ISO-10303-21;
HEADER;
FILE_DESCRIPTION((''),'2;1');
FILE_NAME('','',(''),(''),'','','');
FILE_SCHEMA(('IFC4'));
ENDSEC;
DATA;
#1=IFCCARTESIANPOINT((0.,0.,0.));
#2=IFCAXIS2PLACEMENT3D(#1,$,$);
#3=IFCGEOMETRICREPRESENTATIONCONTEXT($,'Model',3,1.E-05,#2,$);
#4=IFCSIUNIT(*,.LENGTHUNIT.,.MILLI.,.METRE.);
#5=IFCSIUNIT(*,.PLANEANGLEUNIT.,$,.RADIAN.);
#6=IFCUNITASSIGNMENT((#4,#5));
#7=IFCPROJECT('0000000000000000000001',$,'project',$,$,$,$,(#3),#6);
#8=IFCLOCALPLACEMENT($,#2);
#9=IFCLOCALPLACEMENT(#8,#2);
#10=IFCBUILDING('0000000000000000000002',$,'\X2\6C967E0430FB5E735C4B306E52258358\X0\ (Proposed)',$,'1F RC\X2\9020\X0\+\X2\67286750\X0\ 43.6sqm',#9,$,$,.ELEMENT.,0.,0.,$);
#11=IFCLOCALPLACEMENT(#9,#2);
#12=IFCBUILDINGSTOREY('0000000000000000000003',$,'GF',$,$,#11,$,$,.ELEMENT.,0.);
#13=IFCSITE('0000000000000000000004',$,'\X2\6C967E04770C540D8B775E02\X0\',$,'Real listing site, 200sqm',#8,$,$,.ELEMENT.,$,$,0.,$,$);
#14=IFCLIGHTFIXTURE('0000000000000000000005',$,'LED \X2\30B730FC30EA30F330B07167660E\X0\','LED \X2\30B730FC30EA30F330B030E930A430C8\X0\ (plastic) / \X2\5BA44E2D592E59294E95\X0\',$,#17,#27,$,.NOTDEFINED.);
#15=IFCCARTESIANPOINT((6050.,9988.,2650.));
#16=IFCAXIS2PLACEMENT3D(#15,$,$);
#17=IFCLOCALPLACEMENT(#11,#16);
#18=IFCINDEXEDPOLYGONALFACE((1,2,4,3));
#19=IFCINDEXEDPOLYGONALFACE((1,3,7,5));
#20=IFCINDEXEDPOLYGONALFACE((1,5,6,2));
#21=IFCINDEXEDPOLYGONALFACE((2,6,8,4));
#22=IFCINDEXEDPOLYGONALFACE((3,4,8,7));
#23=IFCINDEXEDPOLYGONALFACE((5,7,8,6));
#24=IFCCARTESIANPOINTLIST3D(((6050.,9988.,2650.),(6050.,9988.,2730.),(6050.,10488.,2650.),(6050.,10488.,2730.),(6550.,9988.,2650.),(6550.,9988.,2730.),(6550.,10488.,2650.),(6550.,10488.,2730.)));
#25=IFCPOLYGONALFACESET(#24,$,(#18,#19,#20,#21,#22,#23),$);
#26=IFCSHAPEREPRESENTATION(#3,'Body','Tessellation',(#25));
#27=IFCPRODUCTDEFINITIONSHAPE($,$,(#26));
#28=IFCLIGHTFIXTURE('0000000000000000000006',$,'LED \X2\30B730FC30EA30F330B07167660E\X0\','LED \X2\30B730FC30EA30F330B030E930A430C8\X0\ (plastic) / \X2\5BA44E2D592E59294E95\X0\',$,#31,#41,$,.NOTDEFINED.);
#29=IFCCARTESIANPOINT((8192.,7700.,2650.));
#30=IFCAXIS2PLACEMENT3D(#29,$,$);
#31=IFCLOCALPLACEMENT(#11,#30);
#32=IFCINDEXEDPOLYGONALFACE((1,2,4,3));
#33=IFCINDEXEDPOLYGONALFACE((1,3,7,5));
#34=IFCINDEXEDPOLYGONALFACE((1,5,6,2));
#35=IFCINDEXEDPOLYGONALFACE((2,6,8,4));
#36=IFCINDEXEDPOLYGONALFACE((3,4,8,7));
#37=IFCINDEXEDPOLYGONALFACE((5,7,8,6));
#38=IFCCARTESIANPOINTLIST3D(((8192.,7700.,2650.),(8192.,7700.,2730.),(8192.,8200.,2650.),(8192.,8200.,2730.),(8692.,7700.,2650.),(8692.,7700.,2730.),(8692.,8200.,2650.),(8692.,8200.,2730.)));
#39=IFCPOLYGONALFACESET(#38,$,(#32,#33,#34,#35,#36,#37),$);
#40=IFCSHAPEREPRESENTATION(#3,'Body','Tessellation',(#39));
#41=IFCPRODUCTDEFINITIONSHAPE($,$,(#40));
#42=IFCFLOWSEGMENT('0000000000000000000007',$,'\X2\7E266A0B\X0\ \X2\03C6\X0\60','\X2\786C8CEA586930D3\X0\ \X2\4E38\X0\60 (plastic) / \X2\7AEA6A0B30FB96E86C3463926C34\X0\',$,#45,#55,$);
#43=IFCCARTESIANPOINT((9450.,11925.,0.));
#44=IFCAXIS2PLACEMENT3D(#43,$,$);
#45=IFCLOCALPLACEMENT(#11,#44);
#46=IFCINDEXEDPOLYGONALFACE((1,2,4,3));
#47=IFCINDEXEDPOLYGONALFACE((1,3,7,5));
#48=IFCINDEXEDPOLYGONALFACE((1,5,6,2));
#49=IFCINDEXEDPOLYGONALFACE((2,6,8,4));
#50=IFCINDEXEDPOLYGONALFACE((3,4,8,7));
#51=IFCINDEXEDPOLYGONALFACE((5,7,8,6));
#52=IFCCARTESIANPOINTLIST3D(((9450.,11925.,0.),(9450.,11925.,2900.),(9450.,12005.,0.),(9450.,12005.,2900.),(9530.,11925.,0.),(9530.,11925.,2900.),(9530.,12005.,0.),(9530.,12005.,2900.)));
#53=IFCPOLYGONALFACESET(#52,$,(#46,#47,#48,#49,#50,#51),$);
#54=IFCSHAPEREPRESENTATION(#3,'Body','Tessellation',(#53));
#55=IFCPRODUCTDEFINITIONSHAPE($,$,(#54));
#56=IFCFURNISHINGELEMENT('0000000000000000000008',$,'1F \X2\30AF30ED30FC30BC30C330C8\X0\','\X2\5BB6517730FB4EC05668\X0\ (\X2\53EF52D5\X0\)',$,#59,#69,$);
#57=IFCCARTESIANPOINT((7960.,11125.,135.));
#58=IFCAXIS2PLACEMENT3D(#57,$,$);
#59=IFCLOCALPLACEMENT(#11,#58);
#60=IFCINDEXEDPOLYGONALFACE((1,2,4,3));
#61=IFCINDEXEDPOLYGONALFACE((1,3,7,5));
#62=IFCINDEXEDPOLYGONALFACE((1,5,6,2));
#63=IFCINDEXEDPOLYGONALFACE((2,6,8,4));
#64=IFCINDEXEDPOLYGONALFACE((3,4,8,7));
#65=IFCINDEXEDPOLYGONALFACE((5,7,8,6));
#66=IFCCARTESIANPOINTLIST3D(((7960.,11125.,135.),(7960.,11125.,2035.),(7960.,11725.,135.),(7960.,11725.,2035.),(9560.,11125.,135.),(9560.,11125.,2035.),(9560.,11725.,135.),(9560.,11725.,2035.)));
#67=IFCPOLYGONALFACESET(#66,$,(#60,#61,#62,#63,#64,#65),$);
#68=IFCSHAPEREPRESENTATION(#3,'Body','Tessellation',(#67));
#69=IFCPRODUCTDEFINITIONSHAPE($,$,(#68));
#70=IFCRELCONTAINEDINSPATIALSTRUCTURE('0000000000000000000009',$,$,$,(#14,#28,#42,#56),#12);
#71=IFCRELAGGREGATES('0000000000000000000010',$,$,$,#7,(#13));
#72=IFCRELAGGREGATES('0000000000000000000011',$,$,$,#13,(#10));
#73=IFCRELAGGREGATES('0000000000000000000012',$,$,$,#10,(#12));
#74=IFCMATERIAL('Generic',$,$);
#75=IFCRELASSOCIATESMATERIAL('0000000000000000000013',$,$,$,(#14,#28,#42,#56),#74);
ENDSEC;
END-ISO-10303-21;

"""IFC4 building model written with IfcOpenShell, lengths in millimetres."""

from ifc_helpers import new_model, si_unit, frame, frame_2d, origin, place, context, project, spatial, rectangle, extrude, material, element, save


model = new_model("IFC4")

# Units and contexts
model_context = context("Model", 3, precision=1e-05, world=origin())
ifc_project = project(units=[si_unit("LENGTHUNIT", "METRE", prefix="MILLI"), si_unit("PLANEANGLEUNIT", "RADIAN")], contexts=[model_context])

# Site, building, storey
site_placement = place(None, origin())
site = spatial("IfcSite", under=ifc_project, at=site_placement, Name="沖縄県名護市", ObjectType="Real listing site, 200sqm", CompositionType="ELEMENT", RefElevation=0.0)
building_placement = place(site_placement, origin())
building = spatial("IfcBuilding", under=site, at=building_placement, Name="沖縄・平屋の別荘 (Proposed)", ObjectType="1F RC造+木材 43.6sqm", CompositionType="ELEMENT", ElevationOfRefHeight=0.0, ElevationOfTerrain=0.0)
storey_placement = place(building_placement, origin())
storey = spatial("IfcBuildingStorey", under=building, at=storey_placement, Name="GF", CompositionType="ELEMENT", Elevation=0.0)

# Shared definitions
ifc_material_1 = material(Name="Generic")

# Light fixtures
light_fixture_1_placement = place(storey_placement, frame((6050.0, 9988.0, 2650.0)))
element("IfcLightFixture", 1, at=light_fixture_1_placement, inside=storey, material=ifc_material_1, Name="LED シーリング照明", Description="LED シーリングライト (plastic) / 室中央天井", PredefinedType="NOTDEFINED", context=model_context, shape_type="SweptSolid", body=[
    extrude(rectangle(XDim=500.0, YDim=500.0, at=frame_2d((250.0, 250.0))), frame((6050.0, 9988.0, 2650.0)), (0.0, 0.0, 1.0), 80.0),
])
light_fixture_2_placement = place(storey_placement, frame((8192.0, 7700.0, 2650.0)))
element("IfcLightFixture", 2, at=light_fixture_2_placement, inside=storey, material=ifc_material_1, Name="LED シーリング照明", Description="LED シーリングライト (plastic) / 室中央天井", PredefinedType="NOTDEFINED", context=model_context, shape_type="SweptSolid", body=[
    extrude(rectangle(XDim=500.0, YDim=500.0, at=frame_2d((250.0, 250.0))), frame((8192.0, 7700.0, 2650.0)), (0.0, 0.0, 1.0), 80.0),
])

# Flow segment
flow_segment_placement = place(storey_placement, frame((9450.0, 11925.0, 0.0)))
element("IfcFlowSegment", 3, at=flow_segment_placement, inside=storey, material=ifc_material_1, Name="縦樋 φ60", Description="硬質塩ビ 丸60 (plastic) / 竪樋・雨水排水", context=model_context, shape_type="SweptSolid", body=[
    extrude(rectangle(XDim=80.0, YDim=80.0, at=frame_2d((40.0, 40.0))), frame((9450.0, 11925.0, 0.0)), (0.0, 0.0, 1.0), 2900.0),
])

# Furnishing element
furnishing_placement = place(storey_placement, frame((7960.0, 11125.0, 135.0)))
element("IfcFurnishingElement", 4, at=furnishing_placement, inside=storey, material=ifc_material_1, Name="1F クローゼット", Description="家具・什器 (可動)", context=model_context, shape_type="SweptSolid", body=[
    extrude(rectangle(XDim=1600.0, YDim=600.0, at=frame_2d((800.0, 300.0))), frame((7960.0, 11125.0, 135.0)), (0.0, 0.0, 1.0), 1900.0),
])

save(model, "model.ifc")
